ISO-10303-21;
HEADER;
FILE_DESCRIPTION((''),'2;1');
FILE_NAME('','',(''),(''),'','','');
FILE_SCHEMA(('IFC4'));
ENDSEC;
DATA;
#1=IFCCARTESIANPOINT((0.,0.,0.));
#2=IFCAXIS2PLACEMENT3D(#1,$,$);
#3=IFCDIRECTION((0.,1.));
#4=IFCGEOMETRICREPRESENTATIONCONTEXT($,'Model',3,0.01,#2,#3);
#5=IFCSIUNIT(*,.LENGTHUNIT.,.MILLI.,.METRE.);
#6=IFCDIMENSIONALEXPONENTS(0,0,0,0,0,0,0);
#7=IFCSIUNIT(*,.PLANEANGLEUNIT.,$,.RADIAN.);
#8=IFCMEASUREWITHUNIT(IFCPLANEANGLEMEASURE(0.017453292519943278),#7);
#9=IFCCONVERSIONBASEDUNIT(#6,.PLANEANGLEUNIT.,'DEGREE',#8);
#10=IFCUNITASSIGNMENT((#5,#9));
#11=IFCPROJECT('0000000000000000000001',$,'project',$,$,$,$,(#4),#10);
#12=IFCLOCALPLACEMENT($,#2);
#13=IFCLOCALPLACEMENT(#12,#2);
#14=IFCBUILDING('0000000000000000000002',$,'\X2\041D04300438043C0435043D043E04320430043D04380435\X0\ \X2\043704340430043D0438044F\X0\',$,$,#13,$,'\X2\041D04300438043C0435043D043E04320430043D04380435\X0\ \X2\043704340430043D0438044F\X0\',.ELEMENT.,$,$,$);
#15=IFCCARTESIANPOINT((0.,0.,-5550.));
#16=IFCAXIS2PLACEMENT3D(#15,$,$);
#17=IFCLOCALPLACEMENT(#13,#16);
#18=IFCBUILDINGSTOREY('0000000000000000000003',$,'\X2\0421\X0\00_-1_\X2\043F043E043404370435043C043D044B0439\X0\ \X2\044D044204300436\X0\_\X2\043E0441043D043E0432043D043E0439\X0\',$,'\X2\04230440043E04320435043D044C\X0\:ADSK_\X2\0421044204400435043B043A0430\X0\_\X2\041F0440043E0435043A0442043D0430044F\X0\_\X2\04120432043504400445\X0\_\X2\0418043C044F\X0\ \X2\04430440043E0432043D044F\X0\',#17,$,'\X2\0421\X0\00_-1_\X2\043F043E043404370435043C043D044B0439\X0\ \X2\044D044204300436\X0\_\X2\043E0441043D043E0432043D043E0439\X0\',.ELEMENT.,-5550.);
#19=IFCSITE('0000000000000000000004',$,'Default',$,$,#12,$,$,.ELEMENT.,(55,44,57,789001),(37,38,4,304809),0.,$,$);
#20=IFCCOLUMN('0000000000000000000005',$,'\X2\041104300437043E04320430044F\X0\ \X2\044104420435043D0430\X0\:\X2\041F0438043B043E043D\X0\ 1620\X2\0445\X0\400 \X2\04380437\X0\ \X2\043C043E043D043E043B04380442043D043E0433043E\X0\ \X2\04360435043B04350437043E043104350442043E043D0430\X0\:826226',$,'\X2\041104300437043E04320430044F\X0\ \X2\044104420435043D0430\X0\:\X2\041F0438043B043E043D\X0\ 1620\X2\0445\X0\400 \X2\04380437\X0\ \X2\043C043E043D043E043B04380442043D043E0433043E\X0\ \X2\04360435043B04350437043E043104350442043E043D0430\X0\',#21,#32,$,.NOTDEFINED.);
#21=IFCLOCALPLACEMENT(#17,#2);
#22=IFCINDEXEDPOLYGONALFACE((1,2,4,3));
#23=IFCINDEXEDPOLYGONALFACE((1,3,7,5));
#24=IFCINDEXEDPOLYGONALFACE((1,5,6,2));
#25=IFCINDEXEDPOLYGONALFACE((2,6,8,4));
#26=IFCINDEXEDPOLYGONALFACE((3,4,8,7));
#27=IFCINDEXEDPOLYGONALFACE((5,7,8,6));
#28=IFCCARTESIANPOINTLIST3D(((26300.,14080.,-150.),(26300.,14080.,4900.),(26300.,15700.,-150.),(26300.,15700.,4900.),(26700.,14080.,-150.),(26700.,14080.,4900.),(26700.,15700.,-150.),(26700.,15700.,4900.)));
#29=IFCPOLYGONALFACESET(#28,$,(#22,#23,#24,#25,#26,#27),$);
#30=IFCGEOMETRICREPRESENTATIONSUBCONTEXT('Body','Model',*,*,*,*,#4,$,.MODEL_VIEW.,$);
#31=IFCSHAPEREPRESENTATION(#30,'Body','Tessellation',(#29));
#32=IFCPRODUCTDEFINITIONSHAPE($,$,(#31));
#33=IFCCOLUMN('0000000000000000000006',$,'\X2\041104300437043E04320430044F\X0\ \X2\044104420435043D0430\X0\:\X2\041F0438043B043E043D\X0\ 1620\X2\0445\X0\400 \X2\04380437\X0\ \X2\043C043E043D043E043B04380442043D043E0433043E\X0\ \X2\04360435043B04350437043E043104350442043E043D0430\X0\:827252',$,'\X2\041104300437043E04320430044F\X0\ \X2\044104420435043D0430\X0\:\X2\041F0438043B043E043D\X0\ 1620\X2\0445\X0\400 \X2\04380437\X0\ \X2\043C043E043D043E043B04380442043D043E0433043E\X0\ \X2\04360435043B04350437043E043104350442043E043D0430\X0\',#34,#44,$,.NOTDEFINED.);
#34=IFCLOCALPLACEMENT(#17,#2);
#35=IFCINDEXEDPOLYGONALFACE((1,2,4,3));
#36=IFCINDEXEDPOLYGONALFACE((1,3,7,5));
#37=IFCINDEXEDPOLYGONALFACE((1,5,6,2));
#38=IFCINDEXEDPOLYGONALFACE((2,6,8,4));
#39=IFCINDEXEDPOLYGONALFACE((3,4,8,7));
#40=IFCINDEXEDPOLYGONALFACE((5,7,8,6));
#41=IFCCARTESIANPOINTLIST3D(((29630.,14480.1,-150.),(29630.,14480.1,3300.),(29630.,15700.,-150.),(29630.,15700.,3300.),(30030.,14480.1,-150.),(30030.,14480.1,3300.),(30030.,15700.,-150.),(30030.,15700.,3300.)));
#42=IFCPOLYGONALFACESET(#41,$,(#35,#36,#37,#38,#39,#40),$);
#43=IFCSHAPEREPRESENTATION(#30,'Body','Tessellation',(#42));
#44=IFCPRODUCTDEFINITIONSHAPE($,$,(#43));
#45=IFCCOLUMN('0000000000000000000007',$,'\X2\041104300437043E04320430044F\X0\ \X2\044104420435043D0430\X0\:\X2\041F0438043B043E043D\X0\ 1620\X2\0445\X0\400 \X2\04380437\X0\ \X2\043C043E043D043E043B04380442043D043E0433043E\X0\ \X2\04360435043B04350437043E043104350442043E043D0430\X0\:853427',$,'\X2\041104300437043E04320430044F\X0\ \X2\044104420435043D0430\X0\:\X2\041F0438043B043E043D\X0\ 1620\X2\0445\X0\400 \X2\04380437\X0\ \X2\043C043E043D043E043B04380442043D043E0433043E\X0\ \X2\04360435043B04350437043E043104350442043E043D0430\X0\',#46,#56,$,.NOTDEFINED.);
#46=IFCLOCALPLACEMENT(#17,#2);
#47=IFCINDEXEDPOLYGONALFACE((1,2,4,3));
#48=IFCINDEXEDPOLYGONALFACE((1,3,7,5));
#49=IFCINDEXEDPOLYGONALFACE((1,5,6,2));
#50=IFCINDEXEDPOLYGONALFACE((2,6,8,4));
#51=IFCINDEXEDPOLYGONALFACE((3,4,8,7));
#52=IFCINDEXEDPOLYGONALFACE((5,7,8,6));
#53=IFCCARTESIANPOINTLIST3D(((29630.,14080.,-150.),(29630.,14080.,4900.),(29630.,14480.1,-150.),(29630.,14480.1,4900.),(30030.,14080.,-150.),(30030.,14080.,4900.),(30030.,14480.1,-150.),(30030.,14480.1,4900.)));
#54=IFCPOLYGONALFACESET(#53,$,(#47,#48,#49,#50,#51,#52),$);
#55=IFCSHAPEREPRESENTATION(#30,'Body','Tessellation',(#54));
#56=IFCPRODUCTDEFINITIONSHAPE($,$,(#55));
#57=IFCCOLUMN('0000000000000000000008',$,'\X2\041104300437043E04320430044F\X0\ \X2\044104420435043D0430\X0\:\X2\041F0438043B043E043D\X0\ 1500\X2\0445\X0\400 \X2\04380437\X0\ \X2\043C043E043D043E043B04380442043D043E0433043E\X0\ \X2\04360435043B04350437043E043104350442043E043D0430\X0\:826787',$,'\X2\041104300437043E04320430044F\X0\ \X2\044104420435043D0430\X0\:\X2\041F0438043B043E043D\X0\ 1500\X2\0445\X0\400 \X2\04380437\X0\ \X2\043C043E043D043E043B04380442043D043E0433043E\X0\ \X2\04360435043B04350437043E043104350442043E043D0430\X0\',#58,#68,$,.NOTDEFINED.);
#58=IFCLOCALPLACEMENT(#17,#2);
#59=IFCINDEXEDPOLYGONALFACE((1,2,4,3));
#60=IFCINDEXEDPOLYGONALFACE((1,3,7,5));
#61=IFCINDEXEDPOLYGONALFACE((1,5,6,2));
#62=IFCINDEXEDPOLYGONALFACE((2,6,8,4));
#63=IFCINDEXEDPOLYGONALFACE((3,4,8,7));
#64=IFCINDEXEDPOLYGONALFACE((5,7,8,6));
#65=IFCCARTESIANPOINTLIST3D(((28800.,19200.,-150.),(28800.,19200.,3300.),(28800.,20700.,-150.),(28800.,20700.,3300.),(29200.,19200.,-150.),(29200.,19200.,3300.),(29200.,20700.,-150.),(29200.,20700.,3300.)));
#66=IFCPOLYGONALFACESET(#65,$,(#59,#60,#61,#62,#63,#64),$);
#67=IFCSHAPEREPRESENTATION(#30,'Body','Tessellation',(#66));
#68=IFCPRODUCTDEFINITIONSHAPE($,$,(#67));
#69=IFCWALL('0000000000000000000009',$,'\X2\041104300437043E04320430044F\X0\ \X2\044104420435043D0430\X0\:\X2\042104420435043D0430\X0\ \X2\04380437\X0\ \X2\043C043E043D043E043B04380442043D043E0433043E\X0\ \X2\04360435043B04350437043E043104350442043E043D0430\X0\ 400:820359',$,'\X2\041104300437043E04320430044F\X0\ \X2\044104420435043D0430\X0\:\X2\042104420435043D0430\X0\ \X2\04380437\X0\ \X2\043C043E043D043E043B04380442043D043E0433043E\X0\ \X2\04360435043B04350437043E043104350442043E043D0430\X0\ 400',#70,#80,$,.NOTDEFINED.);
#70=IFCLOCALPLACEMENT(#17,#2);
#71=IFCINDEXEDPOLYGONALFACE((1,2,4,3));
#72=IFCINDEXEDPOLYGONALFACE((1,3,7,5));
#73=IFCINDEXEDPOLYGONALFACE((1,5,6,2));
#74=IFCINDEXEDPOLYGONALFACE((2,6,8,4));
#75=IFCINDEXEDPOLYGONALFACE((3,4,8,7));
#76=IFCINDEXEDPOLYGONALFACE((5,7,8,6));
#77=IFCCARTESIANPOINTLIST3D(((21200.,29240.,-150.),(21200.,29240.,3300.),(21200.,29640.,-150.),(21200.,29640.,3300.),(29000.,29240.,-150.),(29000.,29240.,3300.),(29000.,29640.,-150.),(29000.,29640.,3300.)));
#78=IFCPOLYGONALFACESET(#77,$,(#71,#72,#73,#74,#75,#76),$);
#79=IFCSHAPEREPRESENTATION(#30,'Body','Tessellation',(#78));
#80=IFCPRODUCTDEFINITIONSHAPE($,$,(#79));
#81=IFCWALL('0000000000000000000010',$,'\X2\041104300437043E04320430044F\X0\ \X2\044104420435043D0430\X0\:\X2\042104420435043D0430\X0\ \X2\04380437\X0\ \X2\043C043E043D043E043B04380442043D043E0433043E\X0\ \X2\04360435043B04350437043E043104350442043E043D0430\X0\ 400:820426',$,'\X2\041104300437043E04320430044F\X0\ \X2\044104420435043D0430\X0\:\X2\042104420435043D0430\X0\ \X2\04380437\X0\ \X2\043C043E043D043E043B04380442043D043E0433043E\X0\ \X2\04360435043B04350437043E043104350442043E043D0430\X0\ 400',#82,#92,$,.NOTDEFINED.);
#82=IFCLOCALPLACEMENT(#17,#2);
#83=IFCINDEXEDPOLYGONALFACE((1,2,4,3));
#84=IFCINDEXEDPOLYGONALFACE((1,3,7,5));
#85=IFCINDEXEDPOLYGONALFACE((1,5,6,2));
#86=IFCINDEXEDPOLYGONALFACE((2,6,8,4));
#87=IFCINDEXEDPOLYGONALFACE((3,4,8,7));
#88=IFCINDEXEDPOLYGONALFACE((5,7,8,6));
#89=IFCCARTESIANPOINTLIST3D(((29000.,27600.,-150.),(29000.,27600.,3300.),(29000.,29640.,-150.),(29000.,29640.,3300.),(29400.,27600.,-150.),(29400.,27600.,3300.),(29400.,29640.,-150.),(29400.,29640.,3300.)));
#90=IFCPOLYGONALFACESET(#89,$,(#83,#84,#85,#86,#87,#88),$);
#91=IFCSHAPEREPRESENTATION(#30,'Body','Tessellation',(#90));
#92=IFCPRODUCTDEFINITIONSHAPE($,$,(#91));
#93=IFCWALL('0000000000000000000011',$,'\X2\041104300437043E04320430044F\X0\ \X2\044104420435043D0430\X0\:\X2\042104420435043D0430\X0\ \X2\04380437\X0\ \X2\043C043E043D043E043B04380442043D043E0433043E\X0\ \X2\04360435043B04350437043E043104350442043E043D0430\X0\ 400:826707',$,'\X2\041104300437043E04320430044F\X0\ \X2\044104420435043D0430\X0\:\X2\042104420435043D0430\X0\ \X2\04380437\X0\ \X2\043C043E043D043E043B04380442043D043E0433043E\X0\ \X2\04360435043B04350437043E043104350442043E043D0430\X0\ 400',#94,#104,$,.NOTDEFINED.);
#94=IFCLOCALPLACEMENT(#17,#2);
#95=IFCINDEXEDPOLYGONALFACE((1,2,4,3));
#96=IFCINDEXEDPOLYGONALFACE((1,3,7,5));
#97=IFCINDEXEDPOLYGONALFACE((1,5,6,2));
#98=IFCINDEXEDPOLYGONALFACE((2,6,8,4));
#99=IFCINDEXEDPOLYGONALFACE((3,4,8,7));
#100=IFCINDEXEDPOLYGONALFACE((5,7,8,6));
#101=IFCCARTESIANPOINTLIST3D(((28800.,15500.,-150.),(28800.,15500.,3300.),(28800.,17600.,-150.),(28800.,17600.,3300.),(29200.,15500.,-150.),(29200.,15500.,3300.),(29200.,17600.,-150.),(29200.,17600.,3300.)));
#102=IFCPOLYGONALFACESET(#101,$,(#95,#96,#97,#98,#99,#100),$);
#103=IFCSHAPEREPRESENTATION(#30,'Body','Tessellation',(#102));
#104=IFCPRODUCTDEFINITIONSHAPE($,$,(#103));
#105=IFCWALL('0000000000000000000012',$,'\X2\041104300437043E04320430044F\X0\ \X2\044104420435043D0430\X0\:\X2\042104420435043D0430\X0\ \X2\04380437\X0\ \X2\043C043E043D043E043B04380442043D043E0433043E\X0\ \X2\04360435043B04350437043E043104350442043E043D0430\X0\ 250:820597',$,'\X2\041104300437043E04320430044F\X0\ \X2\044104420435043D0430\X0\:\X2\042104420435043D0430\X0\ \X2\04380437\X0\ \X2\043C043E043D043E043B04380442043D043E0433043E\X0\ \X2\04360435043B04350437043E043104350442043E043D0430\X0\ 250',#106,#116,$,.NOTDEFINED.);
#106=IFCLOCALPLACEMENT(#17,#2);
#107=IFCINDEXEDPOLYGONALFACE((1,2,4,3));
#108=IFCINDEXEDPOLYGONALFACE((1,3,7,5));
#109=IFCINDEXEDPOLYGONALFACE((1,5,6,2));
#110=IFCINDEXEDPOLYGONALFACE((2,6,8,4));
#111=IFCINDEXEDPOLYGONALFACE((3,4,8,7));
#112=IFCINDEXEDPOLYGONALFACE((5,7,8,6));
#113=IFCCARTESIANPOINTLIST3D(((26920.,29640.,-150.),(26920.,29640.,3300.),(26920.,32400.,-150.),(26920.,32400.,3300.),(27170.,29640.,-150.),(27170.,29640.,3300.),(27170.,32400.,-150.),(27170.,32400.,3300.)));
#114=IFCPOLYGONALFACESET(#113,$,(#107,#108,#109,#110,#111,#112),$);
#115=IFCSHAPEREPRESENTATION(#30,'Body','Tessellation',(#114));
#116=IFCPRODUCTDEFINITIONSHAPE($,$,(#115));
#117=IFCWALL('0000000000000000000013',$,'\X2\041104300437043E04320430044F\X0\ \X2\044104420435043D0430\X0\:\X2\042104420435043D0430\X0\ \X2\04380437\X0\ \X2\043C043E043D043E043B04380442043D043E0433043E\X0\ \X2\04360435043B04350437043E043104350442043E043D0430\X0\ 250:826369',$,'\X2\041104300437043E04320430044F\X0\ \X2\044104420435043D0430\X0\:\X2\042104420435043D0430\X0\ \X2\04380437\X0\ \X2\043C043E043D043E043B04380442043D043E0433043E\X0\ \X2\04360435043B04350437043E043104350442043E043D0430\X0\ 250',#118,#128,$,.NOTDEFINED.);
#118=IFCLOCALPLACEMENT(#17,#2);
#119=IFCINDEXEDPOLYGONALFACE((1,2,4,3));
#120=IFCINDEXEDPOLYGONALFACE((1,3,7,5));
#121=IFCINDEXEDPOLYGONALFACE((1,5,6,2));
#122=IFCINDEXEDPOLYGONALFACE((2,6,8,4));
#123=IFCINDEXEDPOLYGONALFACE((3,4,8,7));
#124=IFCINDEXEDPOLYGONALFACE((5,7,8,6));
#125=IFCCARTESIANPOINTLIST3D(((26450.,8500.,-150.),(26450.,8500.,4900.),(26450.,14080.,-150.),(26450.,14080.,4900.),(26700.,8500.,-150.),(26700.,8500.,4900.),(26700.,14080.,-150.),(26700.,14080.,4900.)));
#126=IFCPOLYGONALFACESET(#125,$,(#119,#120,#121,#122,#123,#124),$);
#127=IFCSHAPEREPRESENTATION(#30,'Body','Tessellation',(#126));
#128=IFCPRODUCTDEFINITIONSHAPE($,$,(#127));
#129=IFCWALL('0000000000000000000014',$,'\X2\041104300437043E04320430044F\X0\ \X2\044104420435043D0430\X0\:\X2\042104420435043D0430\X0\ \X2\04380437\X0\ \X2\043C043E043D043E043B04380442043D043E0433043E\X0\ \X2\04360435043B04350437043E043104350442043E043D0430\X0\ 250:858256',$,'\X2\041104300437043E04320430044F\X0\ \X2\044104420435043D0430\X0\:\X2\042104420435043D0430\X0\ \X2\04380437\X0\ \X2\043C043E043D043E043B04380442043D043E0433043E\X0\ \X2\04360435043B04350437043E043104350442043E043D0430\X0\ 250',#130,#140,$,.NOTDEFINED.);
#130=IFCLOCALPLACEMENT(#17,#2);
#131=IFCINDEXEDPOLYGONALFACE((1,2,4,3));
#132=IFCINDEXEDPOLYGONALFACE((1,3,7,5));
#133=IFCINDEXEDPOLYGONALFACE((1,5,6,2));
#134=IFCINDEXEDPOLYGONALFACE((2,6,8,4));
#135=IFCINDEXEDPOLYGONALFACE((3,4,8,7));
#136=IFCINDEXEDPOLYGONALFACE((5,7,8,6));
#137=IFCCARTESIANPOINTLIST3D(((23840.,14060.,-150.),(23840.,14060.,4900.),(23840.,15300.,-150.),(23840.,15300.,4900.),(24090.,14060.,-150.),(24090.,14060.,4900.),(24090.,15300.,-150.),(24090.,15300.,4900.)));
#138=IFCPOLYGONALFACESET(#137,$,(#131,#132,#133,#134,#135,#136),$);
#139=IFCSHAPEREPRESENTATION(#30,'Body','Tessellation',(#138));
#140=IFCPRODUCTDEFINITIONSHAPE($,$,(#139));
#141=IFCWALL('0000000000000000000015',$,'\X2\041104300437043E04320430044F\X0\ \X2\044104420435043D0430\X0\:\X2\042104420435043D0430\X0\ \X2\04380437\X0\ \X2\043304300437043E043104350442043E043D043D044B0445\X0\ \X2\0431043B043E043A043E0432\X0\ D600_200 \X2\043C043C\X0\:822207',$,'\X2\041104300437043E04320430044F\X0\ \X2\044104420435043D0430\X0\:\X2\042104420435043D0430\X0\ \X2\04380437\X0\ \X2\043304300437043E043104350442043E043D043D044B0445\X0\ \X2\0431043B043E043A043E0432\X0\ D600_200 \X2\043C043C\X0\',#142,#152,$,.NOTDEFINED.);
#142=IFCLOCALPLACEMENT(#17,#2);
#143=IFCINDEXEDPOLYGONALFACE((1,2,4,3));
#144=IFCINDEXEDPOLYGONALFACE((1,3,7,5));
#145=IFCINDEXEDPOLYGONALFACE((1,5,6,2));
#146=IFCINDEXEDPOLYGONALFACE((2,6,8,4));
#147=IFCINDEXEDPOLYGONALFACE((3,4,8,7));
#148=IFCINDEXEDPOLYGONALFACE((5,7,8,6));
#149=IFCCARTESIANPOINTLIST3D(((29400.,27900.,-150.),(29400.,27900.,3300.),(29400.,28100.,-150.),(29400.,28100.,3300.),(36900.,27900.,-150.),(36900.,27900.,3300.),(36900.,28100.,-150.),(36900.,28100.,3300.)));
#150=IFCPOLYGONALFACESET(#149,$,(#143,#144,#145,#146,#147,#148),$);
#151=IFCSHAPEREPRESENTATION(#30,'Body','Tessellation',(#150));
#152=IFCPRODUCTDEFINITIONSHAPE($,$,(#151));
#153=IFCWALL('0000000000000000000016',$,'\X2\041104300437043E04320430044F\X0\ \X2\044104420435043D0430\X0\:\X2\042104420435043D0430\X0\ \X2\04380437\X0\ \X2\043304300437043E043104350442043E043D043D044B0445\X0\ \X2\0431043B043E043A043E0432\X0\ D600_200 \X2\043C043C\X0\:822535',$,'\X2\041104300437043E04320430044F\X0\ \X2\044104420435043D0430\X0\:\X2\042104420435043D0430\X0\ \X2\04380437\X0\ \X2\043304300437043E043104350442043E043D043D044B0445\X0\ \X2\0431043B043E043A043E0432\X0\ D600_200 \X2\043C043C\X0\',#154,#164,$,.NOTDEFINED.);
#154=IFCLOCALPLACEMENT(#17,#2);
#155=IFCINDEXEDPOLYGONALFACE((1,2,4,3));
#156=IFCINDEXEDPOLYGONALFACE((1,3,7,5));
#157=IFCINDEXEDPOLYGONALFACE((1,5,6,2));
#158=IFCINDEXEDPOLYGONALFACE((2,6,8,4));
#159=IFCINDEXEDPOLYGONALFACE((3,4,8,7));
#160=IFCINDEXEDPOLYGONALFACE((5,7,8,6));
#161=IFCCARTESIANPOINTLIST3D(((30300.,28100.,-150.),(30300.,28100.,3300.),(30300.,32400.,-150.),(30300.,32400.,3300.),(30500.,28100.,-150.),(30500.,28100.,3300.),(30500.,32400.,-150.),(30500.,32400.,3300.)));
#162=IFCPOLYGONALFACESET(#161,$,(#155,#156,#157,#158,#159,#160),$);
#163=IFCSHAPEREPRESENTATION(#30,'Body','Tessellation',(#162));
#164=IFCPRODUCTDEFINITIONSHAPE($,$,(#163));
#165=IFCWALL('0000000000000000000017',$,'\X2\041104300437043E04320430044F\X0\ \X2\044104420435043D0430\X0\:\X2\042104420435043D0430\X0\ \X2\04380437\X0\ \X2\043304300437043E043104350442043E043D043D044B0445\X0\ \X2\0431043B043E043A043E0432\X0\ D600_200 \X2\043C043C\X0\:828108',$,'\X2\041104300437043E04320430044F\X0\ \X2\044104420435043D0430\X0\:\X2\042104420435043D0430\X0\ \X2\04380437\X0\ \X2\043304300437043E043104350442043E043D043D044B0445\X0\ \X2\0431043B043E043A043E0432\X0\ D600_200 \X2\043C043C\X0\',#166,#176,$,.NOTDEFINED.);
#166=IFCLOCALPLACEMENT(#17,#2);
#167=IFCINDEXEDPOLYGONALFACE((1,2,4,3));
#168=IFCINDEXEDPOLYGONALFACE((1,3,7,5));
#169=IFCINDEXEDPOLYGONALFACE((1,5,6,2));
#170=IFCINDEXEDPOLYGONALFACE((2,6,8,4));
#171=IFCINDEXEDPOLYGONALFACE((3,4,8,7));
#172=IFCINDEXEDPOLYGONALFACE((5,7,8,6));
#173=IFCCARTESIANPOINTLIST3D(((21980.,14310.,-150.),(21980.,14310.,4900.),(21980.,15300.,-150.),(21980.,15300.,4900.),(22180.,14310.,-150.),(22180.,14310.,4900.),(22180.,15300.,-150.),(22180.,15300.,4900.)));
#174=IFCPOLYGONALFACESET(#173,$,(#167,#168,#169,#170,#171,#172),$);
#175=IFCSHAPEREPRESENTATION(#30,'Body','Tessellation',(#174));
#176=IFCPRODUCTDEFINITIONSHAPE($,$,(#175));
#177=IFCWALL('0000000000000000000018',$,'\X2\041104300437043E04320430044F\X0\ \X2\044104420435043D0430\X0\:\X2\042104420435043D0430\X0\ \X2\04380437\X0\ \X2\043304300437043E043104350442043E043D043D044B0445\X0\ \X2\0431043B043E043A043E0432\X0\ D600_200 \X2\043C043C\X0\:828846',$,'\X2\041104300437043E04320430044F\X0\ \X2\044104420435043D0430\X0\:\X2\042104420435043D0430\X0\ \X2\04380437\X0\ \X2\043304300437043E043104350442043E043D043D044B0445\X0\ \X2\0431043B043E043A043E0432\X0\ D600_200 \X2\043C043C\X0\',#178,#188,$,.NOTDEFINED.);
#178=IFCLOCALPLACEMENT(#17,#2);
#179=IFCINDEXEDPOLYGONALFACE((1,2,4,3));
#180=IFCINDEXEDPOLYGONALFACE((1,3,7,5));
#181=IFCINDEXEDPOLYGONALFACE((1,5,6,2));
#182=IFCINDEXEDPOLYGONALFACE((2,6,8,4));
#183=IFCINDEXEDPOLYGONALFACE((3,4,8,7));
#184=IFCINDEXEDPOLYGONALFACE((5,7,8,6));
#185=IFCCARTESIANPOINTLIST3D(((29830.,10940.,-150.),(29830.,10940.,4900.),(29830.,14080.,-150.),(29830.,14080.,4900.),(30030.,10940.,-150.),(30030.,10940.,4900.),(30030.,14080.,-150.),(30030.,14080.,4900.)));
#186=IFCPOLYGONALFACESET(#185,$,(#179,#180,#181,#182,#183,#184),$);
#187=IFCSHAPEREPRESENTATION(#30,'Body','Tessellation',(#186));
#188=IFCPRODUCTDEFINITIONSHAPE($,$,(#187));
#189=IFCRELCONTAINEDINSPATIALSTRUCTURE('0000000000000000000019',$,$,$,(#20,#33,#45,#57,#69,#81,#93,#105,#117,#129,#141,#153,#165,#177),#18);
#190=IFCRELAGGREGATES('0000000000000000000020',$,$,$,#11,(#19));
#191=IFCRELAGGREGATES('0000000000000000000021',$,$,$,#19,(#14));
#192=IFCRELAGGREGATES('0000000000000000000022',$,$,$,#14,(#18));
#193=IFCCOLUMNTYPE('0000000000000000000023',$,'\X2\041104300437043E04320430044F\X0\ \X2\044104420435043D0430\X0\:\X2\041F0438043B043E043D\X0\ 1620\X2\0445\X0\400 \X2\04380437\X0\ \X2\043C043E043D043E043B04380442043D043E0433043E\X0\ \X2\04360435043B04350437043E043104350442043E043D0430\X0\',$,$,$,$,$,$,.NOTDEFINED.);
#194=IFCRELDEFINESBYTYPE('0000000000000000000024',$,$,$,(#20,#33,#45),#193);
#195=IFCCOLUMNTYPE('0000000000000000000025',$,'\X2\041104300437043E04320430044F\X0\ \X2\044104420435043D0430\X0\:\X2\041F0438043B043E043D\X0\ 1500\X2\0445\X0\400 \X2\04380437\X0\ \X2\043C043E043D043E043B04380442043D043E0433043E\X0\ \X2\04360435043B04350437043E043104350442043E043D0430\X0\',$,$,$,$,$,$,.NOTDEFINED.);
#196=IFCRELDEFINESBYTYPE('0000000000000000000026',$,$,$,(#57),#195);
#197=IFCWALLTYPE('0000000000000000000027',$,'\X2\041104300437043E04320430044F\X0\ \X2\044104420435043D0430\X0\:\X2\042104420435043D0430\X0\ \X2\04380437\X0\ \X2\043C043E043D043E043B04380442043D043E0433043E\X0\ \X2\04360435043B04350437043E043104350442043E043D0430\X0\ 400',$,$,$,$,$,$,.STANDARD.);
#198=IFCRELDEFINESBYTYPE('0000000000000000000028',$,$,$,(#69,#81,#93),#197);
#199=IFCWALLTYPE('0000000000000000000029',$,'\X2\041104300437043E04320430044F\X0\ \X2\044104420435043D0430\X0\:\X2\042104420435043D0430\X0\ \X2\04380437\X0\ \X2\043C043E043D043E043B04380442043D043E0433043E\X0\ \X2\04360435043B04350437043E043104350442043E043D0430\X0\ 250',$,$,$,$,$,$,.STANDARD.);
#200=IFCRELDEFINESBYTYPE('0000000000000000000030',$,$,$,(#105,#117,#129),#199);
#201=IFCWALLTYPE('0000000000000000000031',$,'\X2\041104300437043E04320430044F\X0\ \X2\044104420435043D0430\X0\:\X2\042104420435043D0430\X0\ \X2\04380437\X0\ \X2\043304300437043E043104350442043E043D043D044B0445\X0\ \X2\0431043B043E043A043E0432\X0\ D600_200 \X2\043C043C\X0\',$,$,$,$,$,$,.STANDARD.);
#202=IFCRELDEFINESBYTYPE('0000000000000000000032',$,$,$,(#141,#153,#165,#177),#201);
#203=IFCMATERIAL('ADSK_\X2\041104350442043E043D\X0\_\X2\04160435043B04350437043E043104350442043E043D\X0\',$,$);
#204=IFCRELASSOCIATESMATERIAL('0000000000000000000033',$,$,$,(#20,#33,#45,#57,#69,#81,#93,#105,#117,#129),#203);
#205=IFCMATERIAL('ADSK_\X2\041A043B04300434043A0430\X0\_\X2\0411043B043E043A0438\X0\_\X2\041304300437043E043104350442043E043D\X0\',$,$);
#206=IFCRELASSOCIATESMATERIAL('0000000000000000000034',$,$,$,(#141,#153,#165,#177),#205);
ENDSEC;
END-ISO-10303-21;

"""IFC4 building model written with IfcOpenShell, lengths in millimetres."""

from ifc_helpers import new_model, entity, si_unit, converted_unit, direction, frame, origin, place, context, subcontext, project, spatial, indexed_curve, outline, extrude, material, type_object, element, save


model = new_model("IFC4")

# Units and contexts
model_context = context("Model", 3, precision=0.01, world=origin(), true_north=direction((0.0, 1.0)))
body_context = subcontext(model_context, "Body", "Model", "MODEL_VIEW")
ifc_project = project(units=[si_unit("LENGTHUNIT", "METRE", prefix="MILLI"), converted_unit("PLANEANGLEUNIT", "DEGREE", entity("IfcPlaneAngleMeasure", 0.017453292519943278), si_unit("PLANEANGLEUNIT", "RADIAN"), dimensions=[0, 0, 0, 0, 0, 0, 0])], contexts=[model_context])

# Site, building, storey
site_placement = place(None, origin())
site = spatial("IfcSite", under=ifc_project, at=site_placement, Name="Default", CompositionType="ELEMENT", RefLatitude=(55, 44, 57, 789001), RefLongitude=(37, 38, 4, 304809), RefElevation=0.0)
building_placement = place(site_placement, origin())
building = spatial("IfcBuilding", under=site, at=building_placement, Name="Наименование здания", LongName="Наименование здания", CompositionType="ELEMENT")
storey_placement = place(building_placement, frame((0.0, 0.0, -5550.0)))
storey = spatial("IfcBuildingStorey", under=building, at=storey_placement, Name="С00_-1_подземный этаж_основной", ObjectType="Уровень:ADSK_Стрелка_Проектная_Вверх_Имя уровня", LongName="С00_-1_подземный этаж_основной", CompositionType="ELEMENT", Elevation=-5550.0)

# Columns
ifc_material_1 = material(Name="ADSK_Бетон_Железобетон")
column_type_1 = type_object("IfcColumnType", Name="Базовая стена:Пилон 1620х400 из монолитного железобетона", PredefinedType="NOTDEFINED")
column_1_placement = place(storey_placement, frame((26500.0, 15700.0, -150.0), z_axis=(0.0, 0.0, 1.0), x_axis=(0.0, -1.0, 0.0)))
element("IfcColumn", 1, at=column_1_placement, inside=storey, type_object=column_type_1, material=ifc_material_1, Name="Базовая стена:Пилон 1620х400 из монолитного железобетона:826226", ObjectType="Базовая стена:Пилон 1620х400 из монолитного железобетона", PredefinedType="NOTDEFINED", context=body_context, shape_type="SweptSolid", body=[
    extrude(outline(indexed_curve([(1620.0, 200.0), (0.0, 200.0), (0.0, -200.0), (1620.0, -200.0), (1620.0, 200.0)], self_intersect=False)), origin(), (0.0, 0.0, 1.0), 5050.0),
])
column_2_placement = place(storey_placement, frame((29830.0, 15700.0, -150.0), z_axis=(0.0, 0.0, 1.0), x_axis=(0.0, -1.0, 0.0)))
element("IfcColumn", 2, at=column_2_placement, inside=storey, type_object=column_type_1, material=ifc_material_1, Name="Базовая стена:Пилон 1620х400 из монолитного железобетона:827252", ObjectType="Базовая стена:Пилон 1620х400 из монолитного железобетона", PredefinedType="NOTDEFINED", context=body_context, shape_type="SweptSolid", body=[
    extrude(outline(indexed_curve([(1219.9, 200.0), (0.0, 200.0), (0.0, -200.0), (1219.9, -200.0), (1219.9, 200.0)], self_intersect=False)), origin(), (0.0, 0.0, 1.0), 3450.0),
])
column_3_placement = place(storey_placement, frame((29830.0, 14480.1, -150.0), z_axis=(0.0, 0.0, 1.0), x_axis=(0.0, -1.0, 0.0)))
element("IfcColumn", 3, at=column_3_placement, inside=storey, type_object=column_type_1, material=ifc_material_1, Name="Базовая стена:Пилон 1620х400 из монолитного железобетона:853427", ObjectType="Базовая стена:Пилон 1620х400 из монолитного железобетона", PredefinedType="NOTDEFINED", context=body_context, shape_type="SweptSolid", body=[
    extrude(outline(indexed_curve([(400.1, 200.0), (0.0, 200.0), (0.0, -200.0), (400.1, -200.0), (400.1, 200.0)], self_intersect=False)), origin(), (0.0, 0.0, 1.0), 5050.0),
])
column_type_2 = type_object("IfcColumnType", Name="Базовая стена:Пилон 1500х400 из монолитного железобетона", PredefinedType="NOTDEFINED")
column_4_placement = place(storey_placement, frame((29000.0, 19200.0, -150.0), z_axis=(0.0, 0.0, 1.0), x_axis=(0.0, 1.0, 0.0)))
element("IfcColumn", 4, at=column_4_placement, inside=storey, type_object=column_type_2, material=ifc_material_1, Name="Базовая стена:Пилон 1500х400 из монолитного железобетона:826787", ObjectType="Базовая стена:Пилон 1500х400 из монолитного железобетона", PredefinedType="NOTDEFINED", context=body_context, shape_type="SweptSolid", body=[
    extrude(outline(indexed_curve([(1500.0, 200.0), (0.0, 200.0), (0.0, -200.0), (1500.0, -200.0), (1500.0, 200.0)], self_intersect=False)), origin(), (0.0, 0.0, 1.0), 3450.0),
])

# Walls
wall_type_1 = type_object("IfcWallType", Name="Базовая стена:Стена из монолитного железобетона 400", PredefinedType="STANDARD")
wall_1_placement = place(storey_placement, frame((21200.0, 29440.0, -150.0)))
element("IfcWall", 5, at=wall_1_placement, inside=storey, type_object=wall_type_1, material=ifc_material_1, Name="Базовая стена:Стена из монолитного железобетона 400:820359", ObjectType="Базовая стена:Стена из монолитного железобетона 400", PredefinedType="NOTDEFINED", context=body_context, shape_type="SweptSolid", body=[
    extrude(outline(indexed_curve([(7800.0, 200.0), (0.0, 200.0), (0.0, -200.0), (7800.0, -200.0), (7800.0, 200.0)], self_intersect=False)), origin(), (0.0, 0.0, 1.0), 3450.0),
])
wall_2_placement = place(storey_placement, frame((29200.0, 29640.0, -150.0), z_axis=(0.0, 0.0, 1.0), x_axis=(0.0, -1.0, 0.0)))
element("IfcWall", 6, at=wall_2_placement, inside=storey, type_object=wall_type_1, material=ifc_material_1, Name="Базовая стена:Стена из монолитного железобетона 400:820426", ObjectType="Базовая стена:Стена из монолитного железобетона 400", PredefinedType="NOTDEFINED", context=body_context, shape_type="SweptSolid", body=[
    extrude(outline(indexed_curve([(2040.0, 200.0), (0.0, 200.0), (0.0, -200.0), (2040.0, -200.0), (2040.0, 200.0)], self_intersect=False)), origin(), (0.0, 0.0, 1.0), 3450.0),
])
wall_3_placement = place(storey_placement, frame((29000.0, 15500.0, -150.0), z_axis=(0.0, 0.0, 1.0), x_axis=(0.0, 1.0, 0.0)))
element("IfcWall", 7, at=wall_3_placement, inside=storey, type_object=wall_type_1, material=ifc_material_1, Name="Базовая стена:Стена из монолитного железобетона 400:826707", ObjectType="Базовая стена:Стена из монолитного железобетона 400", PredefinedType="NOTDEFINED", context=body_context, shape_type="SweptSolid", body=[
    extrude(outline(indexed_curve([(2100.0, 200.0), (0.0, 200.0), (0.0, -200.0), (2100.0, -200.0), (2100.0, 200.0)], self_intersect=False)), origin(), (0.0, 0.0, 1.0), 3450.0),
])
wall_type_2 = type_object("IfcWallType", Name="Базовая стена:Стена из монолитного железобетона 250", PredefinedType="STANDARD")
wall_4_placement = place(storey_placement, frame((27045.0, 29640.0, -150.0), z_axis=(0.0, 0.0, 1.0), x_axis=(0.0, 1.0, 0.0)))
element("IfcWall", 8, at=wall_4_placement, inside=storey, type_object=wall_type_2, material=ifc_material_1, Name="Базовая стена:Стена из монолитного железобетона 250:820597", ObjectType="Базовая стена:Стена из монолитного железобетона 250", PredefinedType="NOTDEFINED", context=body_context, shape_type="SweptSolid", body=[
    extrude(outline(indexed_curve([(2760.0, 125.0), (0.0, 125.0), (0.0, -125.0), (2760.0, -125.0), (2760.0, 125.0)], self_intersect=False)), origin(), (0.0, 0.0, 1.0), 3450.0),
])
wall_5_placement = place(storey_placement, frame((26575.0, 14080.0, -150.0), z_axis=(0.0, 0.0, 1.0), x_axis=(0.0, -1.0, 0.0)))
element("IfcWall", 9, at=wall_5_placement, inside=storey, type_object=wall_type_2, material=ifc_material_1, Name="Базовая стена:Стена из монолитного железобетона 250:826369", ObjectType="Базовая стена:Стена из монолитного железобетона 250", PredefinedType="NOTDEFINED", context=body_context, shape_type="SweptSolid", body=[
    extrude(outline(indexed_curve([(5580.0, 125.0), (0.0, 125.0), (0.0, -125.0), (5580.0, -125.0), (5580.0, 125.0)], self_intersect=False)), origin(), (0.0, 0.0, 1.0), 5050.0),
])
wall_6_placement = place(storey_placement, frame((23965.0, 14060.0, -150.0), z_axis=(0.0, 0.0, 1.0), x_axis=(0.0, 1.0, 0.0)))
element("IfcWall", 10, at=wall_6_placement, inside=storey, type_object=wall_type_2, material=ifc_material_1, Name="Базовая стена:Стена из монолитного железобетона 250:858256", ObjectType="Базовая стена:Стена из монолитного железобетона 250", PredefinedType="NOTDEFINED", context=body_context, shape_type="SweptSolid", body=[
    extrude(outline(indexed_curve([(1240.0, 125.0), (0.0, 125.0), (0.0, -125.0), (1240.0, -125.0), (1240.0, 125.0)], self_intersect=False)), origin(), (0.0, 0.0, 1.0), 5050.0),
])
ifc_material_2 = material(Name="ADSK_Кладка_Блоки_Газобетон")
wall_type_3 = type_object("IfcWallType", Name="Базовая стена:Стена из газобетонных блоков D600_200 мм", PredefinedType="STANDARD")
wall_7_placement = place(storey_placement, frame((29400.0, 28000.0, -150.0)))
element("IfcWall", 11, at=wall_7_placement, inside=storey, type_object=wall_type_3, material=ifc_material_2, Name="Базовая стена:Стена из газобетонных блоков D600_200 мм:822207", ObjectType="Базовая стена:Стена из газобетонных блоков D600_200 мм", PredefinedType="NOTDEFINED", context=body_context, shape_type="SweptSolid", body=[
    extrude(outline(indexed_curve([(7500.0, 100.0), (0.0, 100.0), (0.0, -100.0), (7500.0, -100.0), (7500.0, 100.0)], self_intersect=False)), origin(), (0.0, 0.0, 1.0), 3450.0),
])
wall_8_placement = place(storey_placement, frame((30400.0, 28100.0, -150.0), z_axis=(0.0, 0.0, 1.0), x_axis=(0.0, 1.0, 0.0)))
element("IfcWall", 12, at=wall_8_placement, inside=storey, type_object=wall_type_3, material=ifc_material_2, Name="Базовая стена:Стена из газобетонных блоков D600_200 мм:822535", ObjectType="Базовая стена:Стена из газобетонных блоков D600_200 мм", PredefinedType="NOTDEFINED", context=body_context, shape_type="SweptSolid", body=[
    extrude(outline(indexed_curve([(4300.0, 100.0), (0.0, 100.0), (0.0, -100.0), (4300.0, -100.0), (4300.0, 100.0)], self_intersect=False)), origin(), (0.0, 0.0, 1.0), 3450.0),
])
wall_9_placement = place(storey_placement, frame((22080.0, 15300.0, -150.0), z_axis=(0.0, 0.0, 1.0), x_axis=(0.0, -1.0, 0.0)))
element("IfcWall", 13, at=wall_9_placement, inside=storey, type_object=wall_type_3, material=ifc_material_2, Name="Базовая стена:Стена из газобетонных блоков D600_200 мм:828108", ObjectType="Базовая стена:Стена из газобетонных блоков D600_200 мм", PredefinedType="NOTDEFINED", context=body_context, shape_type="SweptSolid", body=[
    extrude(outline(indexed_curve([(990.0, 100.0), (0.0, 100.0), (0.0, -100.0), (990.0, -100.0), (990.0, 100.0)], self_intersect=False)), origin(), (0.0, 0.0, 1.0), 5050.0),
])
wall_10_placement = place(storey_placement, frame((29930.0, 14080.0, -150.0), z_axis=(0.0, 0.0, 1.0), x_axis=(0.0, -1.0, 0.0)))
element("IfcWall", 14, at=wall_10_placement, inside=storey, type_object=wall_type_3, material=ifc_material_2, Name="Базовая стена:Стена из газобетонных блоков D600_200 мм:828846", ObjectType="Базовая стена:Стена из газобетонных блоков D600_200 мм", PredefinedType="NOTDEFINED", context=body_context, shape_type="SweptSolid", body=[
    extrude(outline(indexed_curve([(3140.0, 100.0), (0.0, 100.0), (0.0, -100.0), (3140.0, -100.0), (3140.0, 100.0)], self_intersect=False)), origin(), (0.0, 0.0, 1.0), 5050.0),
])

save(model, "model.ifc")
